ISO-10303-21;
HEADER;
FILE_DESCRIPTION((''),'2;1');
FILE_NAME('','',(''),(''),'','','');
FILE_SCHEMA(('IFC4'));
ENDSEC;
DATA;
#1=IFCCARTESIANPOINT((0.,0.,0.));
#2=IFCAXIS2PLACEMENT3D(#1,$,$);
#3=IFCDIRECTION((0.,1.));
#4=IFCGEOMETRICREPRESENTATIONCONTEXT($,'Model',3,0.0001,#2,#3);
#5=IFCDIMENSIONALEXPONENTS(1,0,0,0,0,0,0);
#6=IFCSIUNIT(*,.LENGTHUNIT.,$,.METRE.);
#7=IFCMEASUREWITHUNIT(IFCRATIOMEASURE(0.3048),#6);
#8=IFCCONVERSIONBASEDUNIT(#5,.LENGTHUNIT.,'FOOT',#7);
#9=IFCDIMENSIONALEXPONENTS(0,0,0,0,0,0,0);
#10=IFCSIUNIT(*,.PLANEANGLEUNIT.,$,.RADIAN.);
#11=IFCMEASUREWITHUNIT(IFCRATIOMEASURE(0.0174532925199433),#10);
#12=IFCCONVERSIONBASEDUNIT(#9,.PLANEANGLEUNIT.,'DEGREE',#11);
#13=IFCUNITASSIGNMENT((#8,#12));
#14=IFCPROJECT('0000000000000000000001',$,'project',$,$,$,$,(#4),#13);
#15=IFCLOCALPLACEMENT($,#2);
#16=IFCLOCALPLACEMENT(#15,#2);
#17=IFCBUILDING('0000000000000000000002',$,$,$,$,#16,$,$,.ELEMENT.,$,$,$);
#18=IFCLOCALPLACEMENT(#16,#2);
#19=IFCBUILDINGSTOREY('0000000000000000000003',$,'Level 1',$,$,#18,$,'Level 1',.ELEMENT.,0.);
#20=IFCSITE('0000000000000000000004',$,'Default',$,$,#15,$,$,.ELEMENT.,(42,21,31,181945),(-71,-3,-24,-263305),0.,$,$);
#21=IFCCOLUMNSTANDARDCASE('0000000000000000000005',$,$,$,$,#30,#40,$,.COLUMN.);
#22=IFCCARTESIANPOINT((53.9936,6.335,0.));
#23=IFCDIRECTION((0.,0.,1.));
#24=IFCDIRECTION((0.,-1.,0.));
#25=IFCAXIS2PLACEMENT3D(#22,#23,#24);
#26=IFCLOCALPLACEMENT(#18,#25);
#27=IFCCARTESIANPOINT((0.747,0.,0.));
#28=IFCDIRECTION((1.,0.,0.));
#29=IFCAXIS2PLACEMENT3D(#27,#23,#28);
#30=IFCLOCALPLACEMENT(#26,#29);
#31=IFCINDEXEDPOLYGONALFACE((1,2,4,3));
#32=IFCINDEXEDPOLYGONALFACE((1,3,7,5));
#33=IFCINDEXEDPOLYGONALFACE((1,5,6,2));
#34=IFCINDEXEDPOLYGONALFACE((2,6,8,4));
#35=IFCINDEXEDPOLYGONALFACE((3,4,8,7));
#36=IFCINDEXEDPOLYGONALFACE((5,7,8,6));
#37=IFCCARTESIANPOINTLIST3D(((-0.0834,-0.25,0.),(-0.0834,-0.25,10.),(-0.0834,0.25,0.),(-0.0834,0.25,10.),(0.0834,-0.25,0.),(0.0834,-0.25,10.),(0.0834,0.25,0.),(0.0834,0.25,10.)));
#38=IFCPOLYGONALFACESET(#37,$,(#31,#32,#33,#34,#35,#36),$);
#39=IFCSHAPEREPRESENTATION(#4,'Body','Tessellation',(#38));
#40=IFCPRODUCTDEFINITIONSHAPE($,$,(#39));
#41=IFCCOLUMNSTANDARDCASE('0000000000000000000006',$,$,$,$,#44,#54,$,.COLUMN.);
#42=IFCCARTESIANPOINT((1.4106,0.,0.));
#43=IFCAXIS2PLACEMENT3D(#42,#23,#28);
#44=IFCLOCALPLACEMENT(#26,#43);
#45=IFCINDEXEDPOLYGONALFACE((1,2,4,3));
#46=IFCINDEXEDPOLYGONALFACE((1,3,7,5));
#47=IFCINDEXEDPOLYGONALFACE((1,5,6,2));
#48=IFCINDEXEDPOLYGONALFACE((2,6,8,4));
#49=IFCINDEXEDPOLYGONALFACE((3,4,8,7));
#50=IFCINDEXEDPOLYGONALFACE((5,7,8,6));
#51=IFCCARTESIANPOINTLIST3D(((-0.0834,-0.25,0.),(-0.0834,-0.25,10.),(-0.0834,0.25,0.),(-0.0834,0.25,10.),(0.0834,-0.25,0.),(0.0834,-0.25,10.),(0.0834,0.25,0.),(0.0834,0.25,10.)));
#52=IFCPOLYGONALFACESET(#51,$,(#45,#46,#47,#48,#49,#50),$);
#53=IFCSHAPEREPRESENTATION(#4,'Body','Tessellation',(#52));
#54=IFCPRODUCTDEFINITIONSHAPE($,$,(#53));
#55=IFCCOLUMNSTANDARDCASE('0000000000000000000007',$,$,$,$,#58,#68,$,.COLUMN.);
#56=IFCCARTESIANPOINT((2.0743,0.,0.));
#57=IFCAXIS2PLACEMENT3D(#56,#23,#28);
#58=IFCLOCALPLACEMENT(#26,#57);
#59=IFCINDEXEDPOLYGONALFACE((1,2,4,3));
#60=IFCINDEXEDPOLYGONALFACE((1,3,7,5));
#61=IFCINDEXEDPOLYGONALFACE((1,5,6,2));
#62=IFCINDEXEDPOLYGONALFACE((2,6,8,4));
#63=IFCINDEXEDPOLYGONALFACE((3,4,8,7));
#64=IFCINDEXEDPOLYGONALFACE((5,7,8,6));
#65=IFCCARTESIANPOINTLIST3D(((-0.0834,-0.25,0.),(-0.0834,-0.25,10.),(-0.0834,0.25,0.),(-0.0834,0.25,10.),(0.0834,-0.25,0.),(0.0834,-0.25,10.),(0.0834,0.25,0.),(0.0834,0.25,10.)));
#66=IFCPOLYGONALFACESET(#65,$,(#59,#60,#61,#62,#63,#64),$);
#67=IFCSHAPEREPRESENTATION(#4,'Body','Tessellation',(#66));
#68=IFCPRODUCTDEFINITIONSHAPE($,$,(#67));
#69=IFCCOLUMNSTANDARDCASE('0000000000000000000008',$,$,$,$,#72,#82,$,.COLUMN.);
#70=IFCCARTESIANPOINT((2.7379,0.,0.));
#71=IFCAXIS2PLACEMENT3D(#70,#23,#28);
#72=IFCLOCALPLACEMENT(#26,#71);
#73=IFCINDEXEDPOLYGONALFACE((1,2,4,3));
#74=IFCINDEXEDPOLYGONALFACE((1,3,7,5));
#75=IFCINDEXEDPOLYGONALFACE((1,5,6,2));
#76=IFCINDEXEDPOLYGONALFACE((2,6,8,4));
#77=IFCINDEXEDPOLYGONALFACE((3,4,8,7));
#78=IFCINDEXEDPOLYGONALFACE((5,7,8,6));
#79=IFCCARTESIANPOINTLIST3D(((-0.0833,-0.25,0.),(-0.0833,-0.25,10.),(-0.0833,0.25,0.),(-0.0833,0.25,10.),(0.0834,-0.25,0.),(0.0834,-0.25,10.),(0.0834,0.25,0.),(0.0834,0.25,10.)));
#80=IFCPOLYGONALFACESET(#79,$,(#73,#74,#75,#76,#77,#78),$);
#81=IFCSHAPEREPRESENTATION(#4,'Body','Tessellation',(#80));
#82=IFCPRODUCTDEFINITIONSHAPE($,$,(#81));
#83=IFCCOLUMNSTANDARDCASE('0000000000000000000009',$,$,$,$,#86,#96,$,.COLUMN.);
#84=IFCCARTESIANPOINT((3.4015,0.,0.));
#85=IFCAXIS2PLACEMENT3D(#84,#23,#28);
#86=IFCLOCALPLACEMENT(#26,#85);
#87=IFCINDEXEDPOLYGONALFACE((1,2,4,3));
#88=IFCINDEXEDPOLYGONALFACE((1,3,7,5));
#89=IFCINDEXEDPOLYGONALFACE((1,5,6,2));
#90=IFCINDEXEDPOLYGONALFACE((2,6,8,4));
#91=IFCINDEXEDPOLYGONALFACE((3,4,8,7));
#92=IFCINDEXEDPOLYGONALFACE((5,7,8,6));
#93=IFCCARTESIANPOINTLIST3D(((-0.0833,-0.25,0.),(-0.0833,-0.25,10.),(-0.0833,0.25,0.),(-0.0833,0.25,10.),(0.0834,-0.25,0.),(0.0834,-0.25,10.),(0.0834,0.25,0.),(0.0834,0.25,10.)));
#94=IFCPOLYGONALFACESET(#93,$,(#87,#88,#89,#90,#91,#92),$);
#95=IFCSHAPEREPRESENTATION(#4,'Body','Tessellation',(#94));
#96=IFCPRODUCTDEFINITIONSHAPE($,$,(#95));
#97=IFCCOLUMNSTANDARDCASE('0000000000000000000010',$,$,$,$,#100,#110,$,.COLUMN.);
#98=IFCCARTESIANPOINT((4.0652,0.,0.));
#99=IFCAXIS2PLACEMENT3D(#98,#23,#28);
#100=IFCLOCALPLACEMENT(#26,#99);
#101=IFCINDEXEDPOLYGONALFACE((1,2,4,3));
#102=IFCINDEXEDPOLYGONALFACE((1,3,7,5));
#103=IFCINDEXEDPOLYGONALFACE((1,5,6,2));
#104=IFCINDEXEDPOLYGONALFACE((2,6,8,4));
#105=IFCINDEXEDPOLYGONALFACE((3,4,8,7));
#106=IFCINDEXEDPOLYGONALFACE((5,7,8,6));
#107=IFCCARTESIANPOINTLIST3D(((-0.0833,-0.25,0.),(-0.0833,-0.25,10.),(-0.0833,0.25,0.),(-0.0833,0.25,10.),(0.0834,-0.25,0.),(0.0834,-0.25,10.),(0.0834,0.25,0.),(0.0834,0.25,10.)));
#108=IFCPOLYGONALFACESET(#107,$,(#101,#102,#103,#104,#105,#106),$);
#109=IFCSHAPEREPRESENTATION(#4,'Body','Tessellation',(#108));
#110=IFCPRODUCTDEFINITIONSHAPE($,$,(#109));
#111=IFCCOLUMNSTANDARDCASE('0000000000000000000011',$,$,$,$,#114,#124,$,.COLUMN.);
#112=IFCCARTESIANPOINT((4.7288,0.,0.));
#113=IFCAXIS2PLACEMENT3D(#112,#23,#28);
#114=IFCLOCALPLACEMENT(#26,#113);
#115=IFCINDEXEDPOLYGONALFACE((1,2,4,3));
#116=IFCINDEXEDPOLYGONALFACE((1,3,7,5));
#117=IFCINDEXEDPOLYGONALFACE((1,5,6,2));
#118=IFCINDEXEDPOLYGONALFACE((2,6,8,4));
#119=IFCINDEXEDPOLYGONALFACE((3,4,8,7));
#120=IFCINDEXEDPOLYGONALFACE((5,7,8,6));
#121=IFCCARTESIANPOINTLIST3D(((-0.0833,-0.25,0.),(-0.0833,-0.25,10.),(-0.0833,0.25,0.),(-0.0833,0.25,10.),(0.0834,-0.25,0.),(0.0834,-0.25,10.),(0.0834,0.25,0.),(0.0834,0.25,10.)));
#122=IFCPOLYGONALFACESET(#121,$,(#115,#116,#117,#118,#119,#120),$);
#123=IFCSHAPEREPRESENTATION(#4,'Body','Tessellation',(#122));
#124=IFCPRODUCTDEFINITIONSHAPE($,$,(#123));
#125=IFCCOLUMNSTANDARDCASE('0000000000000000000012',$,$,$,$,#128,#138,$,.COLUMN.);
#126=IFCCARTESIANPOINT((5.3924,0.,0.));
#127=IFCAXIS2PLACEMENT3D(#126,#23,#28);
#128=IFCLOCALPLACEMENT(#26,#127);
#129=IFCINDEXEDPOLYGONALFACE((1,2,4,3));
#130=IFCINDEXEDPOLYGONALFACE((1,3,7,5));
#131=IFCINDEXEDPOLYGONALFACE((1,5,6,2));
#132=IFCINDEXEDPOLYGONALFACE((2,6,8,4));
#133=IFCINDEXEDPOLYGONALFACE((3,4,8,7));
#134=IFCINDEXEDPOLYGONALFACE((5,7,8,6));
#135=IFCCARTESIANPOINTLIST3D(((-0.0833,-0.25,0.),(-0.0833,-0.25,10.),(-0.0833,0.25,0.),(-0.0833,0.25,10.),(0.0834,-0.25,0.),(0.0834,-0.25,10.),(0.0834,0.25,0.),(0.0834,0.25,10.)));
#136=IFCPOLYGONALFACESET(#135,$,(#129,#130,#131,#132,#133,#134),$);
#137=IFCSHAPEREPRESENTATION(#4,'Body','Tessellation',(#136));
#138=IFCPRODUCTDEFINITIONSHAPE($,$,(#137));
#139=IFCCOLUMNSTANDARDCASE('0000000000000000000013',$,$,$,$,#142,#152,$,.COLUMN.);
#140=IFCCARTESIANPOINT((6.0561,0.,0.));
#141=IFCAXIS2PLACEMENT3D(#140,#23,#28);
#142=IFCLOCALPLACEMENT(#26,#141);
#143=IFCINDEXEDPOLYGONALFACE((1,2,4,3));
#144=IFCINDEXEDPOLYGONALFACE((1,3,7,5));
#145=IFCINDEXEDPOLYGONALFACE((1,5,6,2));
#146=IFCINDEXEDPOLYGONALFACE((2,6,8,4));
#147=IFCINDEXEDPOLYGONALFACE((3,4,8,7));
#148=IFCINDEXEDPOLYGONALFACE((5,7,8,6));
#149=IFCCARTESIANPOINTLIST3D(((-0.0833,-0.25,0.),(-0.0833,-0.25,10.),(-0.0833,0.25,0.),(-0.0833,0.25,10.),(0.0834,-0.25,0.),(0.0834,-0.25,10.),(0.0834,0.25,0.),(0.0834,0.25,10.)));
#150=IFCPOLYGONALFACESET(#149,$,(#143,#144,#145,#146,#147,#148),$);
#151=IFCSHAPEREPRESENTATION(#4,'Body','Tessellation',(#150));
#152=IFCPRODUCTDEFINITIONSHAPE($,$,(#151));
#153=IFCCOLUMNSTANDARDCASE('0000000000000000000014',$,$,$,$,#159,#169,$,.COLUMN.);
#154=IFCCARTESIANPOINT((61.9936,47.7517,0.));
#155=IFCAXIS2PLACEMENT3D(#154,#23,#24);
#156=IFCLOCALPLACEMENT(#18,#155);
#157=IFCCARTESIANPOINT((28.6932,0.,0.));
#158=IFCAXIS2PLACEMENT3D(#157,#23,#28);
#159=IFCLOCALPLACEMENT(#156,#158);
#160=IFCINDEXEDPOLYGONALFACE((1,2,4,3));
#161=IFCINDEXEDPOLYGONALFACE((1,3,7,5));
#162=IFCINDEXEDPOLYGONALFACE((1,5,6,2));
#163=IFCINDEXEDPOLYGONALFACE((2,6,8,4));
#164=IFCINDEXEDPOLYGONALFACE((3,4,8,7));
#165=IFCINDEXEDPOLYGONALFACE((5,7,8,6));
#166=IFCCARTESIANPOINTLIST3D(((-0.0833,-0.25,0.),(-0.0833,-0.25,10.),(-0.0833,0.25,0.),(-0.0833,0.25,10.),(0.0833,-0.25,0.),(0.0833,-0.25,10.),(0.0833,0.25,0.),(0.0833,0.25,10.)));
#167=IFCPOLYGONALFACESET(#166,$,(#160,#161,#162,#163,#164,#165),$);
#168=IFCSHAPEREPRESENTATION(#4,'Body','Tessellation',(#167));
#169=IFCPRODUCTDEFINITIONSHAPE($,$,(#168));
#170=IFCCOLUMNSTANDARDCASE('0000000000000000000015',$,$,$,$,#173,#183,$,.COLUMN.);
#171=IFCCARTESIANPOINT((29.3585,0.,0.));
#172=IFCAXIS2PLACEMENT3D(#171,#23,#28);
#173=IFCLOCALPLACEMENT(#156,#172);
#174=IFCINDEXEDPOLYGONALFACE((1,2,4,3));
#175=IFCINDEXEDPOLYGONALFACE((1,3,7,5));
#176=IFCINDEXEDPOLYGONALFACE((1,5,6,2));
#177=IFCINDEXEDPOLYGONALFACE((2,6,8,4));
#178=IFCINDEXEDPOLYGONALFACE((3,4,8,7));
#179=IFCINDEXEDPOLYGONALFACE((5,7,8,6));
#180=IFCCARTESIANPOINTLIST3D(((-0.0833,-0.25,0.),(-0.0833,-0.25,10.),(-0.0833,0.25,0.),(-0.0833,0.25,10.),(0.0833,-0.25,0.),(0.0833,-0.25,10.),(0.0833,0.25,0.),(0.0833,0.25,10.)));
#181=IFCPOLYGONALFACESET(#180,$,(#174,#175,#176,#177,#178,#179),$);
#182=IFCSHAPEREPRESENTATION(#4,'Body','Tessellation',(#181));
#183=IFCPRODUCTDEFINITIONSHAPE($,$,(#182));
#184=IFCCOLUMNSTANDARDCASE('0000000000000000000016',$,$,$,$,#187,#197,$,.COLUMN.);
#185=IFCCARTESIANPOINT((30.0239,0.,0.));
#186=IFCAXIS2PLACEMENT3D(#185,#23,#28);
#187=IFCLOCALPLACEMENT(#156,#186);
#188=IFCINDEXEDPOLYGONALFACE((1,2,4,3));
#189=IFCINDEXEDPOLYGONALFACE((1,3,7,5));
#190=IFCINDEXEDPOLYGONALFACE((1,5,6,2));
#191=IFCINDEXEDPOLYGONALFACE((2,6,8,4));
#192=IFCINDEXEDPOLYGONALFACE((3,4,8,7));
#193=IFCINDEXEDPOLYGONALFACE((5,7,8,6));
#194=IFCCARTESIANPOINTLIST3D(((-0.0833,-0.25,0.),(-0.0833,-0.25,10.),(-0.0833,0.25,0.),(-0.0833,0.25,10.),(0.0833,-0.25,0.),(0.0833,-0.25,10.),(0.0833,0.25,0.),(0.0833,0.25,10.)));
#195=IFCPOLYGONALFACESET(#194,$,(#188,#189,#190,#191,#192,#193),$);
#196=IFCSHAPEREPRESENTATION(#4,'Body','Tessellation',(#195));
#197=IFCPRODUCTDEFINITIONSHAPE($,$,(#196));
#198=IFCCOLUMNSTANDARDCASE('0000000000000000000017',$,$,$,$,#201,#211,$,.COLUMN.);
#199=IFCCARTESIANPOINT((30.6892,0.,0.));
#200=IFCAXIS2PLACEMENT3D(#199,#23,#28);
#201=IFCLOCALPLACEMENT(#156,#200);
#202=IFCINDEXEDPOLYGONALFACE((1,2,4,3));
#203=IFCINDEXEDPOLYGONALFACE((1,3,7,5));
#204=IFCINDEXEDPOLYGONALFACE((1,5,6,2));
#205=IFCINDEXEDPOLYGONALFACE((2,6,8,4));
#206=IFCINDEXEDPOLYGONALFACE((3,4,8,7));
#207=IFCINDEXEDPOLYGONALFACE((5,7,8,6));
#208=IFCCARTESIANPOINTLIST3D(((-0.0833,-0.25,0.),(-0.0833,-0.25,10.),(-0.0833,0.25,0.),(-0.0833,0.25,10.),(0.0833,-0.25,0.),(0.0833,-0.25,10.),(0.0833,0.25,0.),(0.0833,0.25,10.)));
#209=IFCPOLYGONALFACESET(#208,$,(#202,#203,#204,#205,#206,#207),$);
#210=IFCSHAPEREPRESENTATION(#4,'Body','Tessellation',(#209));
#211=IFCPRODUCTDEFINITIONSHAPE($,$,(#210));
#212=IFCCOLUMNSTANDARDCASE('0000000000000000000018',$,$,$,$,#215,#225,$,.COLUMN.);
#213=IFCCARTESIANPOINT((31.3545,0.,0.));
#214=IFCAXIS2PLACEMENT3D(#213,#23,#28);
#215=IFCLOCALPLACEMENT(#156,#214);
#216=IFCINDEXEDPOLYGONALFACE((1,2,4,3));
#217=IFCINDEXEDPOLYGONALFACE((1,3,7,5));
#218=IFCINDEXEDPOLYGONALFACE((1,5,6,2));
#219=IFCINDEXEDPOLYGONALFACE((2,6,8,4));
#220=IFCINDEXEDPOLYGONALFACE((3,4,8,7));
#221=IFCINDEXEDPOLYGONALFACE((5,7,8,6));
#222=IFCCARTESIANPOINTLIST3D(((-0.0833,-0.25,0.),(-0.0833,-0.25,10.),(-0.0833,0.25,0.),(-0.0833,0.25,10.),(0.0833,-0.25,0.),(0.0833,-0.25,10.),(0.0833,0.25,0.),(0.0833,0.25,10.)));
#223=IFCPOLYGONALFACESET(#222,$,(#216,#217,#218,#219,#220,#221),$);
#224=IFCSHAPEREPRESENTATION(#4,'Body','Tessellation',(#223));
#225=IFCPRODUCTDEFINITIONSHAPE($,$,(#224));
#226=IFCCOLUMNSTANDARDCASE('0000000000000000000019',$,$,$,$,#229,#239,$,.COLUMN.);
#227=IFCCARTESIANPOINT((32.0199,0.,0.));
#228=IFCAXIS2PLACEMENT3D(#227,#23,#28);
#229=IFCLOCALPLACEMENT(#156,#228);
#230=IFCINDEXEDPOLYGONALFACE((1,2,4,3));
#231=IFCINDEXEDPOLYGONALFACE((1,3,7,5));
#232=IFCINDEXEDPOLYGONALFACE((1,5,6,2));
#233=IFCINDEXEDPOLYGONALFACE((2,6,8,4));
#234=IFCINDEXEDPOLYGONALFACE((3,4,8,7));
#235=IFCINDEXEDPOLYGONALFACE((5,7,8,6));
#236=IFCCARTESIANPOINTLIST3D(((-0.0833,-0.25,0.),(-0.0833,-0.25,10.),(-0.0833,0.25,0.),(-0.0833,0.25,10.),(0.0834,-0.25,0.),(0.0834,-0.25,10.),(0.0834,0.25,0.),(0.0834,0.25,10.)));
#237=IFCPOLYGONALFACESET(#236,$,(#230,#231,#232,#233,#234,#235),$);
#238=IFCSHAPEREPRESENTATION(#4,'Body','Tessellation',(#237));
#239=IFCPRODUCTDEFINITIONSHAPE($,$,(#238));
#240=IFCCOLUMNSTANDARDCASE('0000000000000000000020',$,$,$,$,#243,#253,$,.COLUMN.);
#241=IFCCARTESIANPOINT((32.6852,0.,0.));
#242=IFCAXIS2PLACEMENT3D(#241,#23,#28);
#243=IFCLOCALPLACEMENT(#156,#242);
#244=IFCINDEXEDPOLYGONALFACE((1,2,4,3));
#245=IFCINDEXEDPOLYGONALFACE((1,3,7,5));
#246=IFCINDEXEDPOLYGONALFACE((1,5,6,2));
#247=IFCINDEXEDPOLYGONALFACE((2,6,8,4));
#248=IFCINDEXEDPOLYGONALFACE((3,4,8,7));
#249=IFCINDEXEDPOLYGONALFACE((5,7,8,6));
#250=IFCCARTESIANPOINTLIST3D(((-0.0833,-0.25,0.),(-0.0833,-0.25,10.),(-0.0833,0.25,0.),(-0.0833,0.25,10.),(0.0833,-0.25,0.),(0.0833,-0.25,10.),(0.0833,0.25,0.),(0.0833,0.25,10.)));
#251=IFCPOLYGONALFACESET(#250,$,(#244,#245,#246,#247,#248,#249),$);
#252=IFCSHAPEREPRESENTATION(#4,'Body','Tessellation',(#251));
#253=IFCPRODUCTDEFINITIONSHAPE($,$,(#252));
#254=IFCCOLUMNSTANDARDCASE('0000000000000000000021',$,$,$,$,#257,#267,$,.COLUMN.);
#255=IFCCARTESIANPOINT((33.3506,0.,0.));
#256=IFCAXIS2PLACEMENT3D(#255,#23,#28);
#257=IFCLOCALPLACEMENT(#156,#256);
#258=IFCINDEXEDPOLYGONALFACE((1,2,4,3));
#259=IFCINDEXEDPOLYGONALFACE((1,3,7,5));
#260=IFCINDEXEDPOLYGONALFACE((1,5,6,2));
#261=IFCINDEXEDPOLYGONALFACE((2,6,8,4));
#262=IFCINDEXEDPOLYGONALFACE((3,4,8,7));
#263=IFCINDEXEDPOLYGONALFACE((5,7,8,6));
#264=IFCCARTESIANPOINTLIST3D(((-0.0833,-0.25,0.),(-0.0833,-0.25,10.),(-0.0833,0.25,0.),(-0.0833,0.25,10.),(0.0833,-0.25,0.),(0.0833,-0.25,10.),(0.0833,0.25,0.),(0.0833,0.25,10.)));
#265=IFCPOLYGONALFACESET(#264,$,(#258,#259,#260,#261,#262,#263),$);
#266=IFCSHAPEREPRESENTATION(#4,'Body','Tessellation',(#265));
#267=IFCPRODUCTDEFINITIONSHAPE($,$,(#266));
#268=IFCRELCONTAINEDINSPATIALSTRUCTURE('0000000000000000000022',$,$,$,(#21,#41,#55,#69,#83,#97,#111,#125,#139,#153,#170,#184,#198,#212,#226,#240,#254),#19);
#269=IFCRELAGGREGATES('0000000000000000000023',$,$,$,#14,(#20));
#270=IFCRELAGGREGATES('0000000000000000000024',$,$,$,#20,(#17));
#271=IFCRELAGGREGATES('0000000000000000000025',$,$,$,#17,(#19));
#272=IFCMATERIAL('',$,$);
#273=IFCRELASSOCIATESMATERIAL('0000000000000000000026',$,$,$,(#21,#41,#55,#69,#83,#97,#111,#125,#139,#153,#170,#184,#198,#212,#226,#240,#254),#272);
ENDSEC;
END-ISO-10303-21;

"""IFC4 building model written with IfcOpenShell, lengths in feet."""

from ifc_helpers import new_model, entity, si_unit, converted_unit, direction, frame, origin, place, context, project, spatial, rectangle, extrude, material, element, save


model = new_model("IFC4")

# Units and contexts
model_context = context("Model", 3, precision=0.0001, world=origin(), true_north=direction((0.0, 1.0)))
ifc_project = project(units=[converted_unit("LENGTHUNIT", "FOOT", entity("IfcRatioMeasure", 0.3048), si_unit("LENGTHUNIT", "METRE"), dimensions=[1, 0, 0, 0, 0, 0, 0]), converted_unit("PLANEANGLEUNIT", "DEGREE", entity("IfcRatioMeasure", 0.0174532925199433), si_unit("PLANEANGLEUNIT", "RADIAN"), dimensions=[0, 0, 0, 0, 0, 0, 0])], contexts=[model_context])

# Site, building, storey
site_placement = place(None, origin())
site = spatial("IfcSite", under=ifc_project, at=site_placement, Name="Default", CompositionType="ELEMENT", RefLatitude=(42, 21, 31, 181945), RefLongitude=(-71, -3, -24, -263305), RefElevation=0.0)
building_placement = place(site_placement, origin())
building = spatial("IfcBuilding", under=site, at=building_placement, CompositionType="ELEMENT")
storey_placement = place(building_placement, origin())
storey = spatial("IfcBuildingStorey", under=building, at=storey_placement, Name="Level 1", LongName="Level 1", CompositionType="ELEMENT", Elevation=0.0)

# Columns
ifc_material_1 = material(Name="")
wall_1_placement = place(storey_placement, frame((53.9936, 6.335, 0.0), z_axis=(0.0, 0.0, 1.0), x_axis=(0.0, -1.0, 0.0)))
for number, where, z_axis, x_axis in (
    (1, (0.747, 0.0, 0.0), (0.0, 0.0, 1.0), (1.0, 0.0, 0.0)),
    (2, (1.4106, 0.0, 0.0), (0.0, 0.0, 1.0), (1.0, 0.0, 0.0)),
    (3, (2.0743, 0.0, 0.0), (0.0, 0.0, 1.0), (1.0, 0.0, 0.0)),
    (4, (2.7379, 0.0, 0.0), (0.0, 0.0, 1.0), (1.0, 0.0, 0.0)),
    (5, (3.4015, 0.0, 0.0), (0.0, 0.0, 1.0), (1.0, 0.0, 0.0)),
    (6, (4.0652, 0.0, 0.0), (0.0, 0.0, 1.0), (1.0, 0.0, 0.0)),
    (7, (4.7288, 0.0, 0.0), (0.0, 0.0, 1.0), (1.0, 0.0, 0.0)),
    (8, (5.3924, 0.0, 0.0), (0.0, 0.0, 1.0), (1.0, 0.0, 0.0)),
    (9, (6.0561, 0.0, 0.0), (0.0, 0.0, 1.0), (1.0, 0.0, 0.0)),
):
    element("IfcColumnStandardCase", number, at=place(wall_1_placement, frame(where, z_axis=z_axis, x_axis=x_axis)), inside=storey, material=ifc_material_1, PredefinedType="COLUMN", context=model_context, shape_type="SweptSolid", body=[
        extrude(rectangle(XDim=0.1667, YDim=0.5), origin(), (0.0, 0.0, 1.0), 10.0),
    ])
placement = place(storey_placement, frame((61.9936, 47.7517, 0.0), z_axis=(0.0, 0.0, 1.0), x_axis=(0.0, -1.0, 0.0)))
for number, where, z_axis, x_axis in (
    (10, (28.6932, 0.0, 0.0), (0.0, 0.0, 1.0), (1.0, 0.0, 0.0)),
    (11, (29.3585, 0.0, 0.0), (0.0, 0.0, 1.0), (1.0, 0.0, 0.0)),
    (12, (30.0239, 0.0, 0.0), (0.0, 0.0, 1.0), (1.0, 0.0, 0.0)),
    (13, (30.6892, 0.0, 0.0), (0.0, 0.0, 1.0), (1.0, 0.0, 0.0)),
    (14, (31.3545, 0.0, 0.0), (0.0, 0.0, 1.0), (1.0, 0.0, 0.0)),
    (15, (32.0199, 0.0, 0.0), (0.0, 0.0, 1.0), (1.0, 0.0, 0.0)),
    (16, (32.6852, 0.0, 0.0), (0.0, 0.0, 1.0), (1.0, 0.0, 0.0)),
    (17, (33.3506, 0.0, 0.0), (0.0, 0.0, 1.0), (1.0, 0.0, 0.0)),
):
    element("IfcColumnStandardCase", number, at=place(placement, frame(where, z_axis=z_axis, x_axis=x_axis)), inside=storey, material=ifc_material_1, PredefinedType="COLUMN", context=model_context, shape_type="SweptSolid", body=[
        extrude(rectangle(XDim=0.1667, YDim=0.5), origin(), (0.0, 0.0, 1.0), 10.0),
    ])

save(model, "model.ifc")
